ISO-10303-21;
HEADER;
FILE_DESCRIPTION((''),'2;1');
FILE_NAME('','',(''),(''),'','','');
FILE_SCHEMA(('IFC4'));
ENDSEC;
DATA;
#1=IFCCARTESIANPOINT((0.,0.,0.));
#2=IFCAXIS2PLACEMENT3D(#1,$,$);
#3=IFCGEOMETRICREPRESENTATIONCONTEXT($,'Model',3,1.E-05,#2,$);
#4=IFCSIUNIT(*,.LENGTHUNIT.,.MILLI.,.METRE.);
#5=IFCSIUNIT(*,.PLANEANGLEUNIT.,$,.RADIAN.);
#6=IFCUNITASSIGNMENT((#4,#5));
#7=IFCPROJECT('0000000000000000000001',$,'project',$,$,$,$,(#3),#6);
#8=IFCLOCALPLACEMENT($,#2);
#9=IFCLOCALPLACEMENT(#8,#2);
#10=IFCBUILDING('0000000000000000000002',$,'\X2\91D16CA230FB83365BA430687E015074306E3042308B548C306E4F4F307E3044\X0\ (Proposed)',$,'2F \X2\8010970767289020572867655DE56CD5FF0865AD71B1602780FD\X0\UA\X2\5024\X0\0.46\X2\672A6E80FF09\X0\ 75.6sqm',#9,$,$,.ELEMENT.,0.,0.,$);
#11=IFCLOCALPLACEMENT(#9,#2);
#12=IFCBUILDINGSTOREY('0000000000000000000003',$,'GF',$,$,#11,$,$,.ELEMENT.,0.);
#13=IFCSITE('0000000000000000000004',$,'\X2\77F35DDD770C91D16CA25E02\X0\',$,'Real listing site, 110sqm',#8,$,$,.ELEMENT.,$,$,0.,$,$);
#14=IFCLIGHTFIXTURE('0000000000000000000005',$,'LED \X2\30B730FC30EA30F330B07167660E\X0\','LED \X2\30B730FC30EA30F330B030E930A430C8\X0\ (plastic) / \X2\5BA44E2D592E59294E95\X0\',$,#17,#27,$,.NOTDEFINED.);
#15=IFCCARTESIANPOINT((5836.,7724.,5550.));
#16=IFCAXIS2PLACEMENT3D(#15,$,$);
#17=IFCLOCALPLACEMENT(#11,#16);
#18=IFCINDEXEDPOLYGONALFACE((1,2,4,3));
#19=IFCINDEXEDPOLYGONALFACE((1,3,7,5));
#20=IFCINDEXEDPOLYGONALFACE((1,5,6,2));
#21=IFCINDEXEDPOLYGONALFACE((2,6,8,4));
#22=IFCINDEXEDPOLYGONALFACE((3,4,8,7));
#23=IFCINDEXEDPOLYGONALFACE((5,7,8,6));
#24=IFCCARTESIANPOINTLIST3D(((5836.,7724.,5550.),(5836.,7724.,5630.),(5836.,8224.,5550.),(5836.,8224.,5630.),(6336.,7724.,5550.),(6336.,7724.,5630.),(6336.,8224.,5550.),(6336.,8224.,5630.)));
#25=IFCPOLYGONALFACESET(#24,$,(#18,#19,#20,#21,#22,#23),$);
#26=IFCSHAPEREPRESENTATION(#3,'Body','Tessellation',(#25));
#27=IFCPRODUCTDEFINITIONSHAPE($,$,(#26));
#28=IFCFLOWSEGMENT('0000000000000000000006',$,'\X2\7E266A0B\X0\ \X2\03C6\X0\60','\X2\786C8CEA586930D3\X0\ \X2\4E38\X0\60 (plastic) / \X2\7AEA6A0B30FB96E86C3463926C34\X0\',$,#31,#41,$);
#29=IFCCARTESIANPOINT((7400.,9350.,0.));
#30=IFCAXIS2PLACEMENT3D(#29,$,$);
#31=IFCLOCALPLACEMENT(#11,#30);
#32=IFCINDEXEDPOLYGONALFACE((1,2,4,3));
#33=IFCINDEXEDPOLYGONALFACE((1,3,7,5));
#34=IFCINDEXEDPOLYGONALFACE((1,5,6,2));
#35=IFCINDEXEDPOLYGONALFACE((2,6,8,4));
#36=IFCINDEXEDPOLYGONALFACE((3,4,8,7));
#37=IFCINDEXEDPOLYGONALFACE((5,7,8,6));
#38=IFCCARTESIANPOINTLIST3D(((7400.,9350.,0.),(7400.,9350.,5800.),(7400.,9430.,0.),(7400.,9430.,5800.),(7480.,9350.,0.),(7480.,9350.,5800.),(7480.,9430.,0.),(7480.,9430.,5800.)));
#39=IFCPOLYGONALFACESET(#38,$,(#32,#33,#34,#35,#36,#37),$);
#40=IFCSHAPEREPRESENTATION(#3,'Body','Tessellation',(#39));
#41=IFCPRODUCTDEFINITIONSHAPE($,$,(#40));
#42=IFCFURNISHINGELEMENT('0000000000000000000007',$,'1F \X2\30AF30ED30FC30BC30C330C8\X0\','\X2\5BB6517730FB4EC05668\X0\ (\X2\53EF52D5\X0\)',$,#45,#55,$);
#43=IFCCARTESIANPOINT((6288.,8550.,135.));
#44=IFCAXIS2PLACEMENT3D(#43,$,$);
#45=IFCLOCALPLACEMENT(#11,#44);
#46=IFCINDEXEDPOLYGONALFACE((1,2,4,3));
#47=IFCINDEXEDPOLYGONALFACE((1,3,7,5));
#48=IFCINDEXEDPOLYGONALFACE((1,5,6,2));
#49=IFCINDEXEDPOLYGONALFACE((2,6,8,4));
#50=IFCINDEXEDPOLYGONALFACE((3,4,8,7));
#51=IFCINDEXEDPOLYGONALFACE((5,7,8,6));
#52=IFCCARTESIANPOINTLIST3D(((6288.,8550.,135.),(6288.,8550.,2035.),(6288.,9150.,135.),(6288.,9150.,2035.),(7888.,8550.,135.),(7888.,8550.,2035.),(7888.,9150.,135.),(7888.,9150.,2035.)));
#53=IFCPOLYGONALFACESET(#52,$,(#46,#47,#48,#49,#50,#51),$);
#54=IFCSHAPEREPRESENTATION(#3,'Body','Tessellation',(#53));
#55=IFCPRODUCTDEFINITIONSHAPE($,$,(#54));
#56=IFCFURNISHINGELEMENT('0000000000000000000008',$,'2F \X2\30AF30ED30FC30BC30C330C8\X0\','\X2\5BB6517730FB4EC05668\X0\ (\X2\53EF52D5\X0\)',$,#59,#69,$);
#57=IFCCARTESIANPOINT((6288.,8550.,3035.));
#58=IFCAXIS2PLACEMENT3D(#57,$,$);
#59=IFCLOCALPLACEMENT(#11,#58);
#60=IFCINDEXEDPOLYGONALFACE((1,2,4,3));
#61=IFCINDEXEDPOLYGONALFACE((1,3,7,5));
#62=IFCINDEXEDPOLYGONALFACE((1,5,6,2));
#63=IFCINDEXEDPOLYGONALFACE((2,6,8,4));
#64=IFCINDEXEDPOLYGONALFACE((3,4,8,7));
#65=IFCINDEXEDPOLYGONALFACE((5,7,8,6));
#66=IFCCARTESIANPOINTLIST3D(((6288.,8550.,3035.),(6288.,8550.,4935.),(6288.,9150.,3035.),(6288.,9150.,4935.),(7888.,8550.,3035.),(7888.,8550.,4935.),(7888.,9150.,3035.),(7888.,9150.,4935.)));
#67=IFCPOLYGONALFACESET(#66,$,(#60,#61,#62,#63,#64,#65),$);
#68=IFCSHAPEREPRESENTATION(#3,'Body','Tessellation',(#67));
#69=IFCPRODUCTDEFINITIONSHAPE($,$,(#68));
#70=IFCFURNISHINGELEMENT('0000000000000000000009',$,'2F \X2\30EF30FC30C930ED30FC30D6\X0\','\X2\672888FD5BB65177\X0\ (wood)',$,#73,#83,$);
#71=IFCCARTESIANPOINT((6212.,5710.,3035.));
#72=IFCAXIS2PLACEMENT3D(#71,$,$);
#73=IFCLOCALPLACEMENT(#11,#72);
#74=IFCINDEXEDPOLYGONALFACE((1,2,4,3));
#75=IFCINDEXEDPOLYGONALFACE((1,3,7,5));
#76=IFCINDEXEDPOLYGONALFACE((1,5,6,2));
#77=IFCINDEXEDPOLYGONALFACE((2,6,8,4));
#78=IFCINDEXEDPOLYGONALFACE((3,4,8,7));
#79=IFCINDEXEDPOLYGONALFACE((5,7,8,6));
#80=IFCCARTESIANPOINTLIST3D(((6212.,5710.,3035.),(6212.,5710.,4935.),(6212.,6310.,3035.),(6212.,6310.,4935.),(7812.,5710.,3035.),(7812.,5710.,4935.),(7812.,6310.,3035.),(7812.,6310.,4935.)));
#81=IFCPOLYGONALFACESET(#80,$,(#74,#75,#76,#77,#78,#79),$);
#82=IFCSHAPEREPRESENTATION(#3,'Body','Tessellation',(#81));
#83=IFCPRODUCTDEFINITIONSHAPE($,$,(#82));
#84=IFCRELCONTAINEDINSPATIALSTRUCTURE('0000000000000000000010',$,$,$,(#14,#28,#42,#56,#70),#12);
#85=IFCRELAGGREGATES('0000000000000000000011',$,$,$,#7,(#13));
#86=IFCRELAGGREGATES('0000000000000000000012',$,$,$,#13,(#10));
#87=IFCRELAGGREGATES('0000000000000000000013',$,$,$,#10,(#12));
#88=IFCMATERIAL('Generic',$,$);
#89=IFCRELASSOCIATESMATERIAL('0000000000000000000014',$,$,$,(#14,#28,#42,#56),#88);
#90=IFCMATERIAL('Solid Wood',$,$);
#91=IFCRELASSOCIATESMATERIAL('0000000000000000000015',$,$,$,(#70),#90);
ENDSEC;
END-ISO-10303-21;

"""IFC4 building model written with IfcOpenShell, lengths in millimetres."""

from ifc_helpers import new_model, si_unit, frame, frame_2d, origin, place, context, project, spatial, rectangle, extrude, material, element, save


model = new_model("IFC4")

# Units and contexts
model_context = context("Model", 3, precision=1e-05, world=origin())
ifc_project = project(units=[si_unit("LENGTHUNIT", "METRE", prefix="MILLI"), si_unit("PLANEANGLEUNIT", "RADIAN")], contexts=[model_context])

# Site, building, storey
site_placement = place(None, origin())
site = spatial("IfcSite", under=ifc_project, at=site_placement, Name="石川県金沢市", ObjectType="Real listing site, 110sqm", CompositionType="ELEMENT", RefElevation=0.0)
building_placement = place(site_placement, origin())
building = spatial("IfcBuilding", under=site, at=building_placement, Name="金沢・茶室と縁側のある和の住まい (Proposed)", ObjectType="2F 耐震木造在来工法（断熱性能UA値0.46未満） 75.6sqm", CompositionType="ELEMENT", ElevationOfRefHeight=0.0, ElevationOfTerrain=0.0)
storey_placement = place(building_placement, origin())
storey = spatial("IfcBuildingStorey", under=building, at=storey_placement, Name="GF", CompositionType="ELEMENT", Elevation=0.0)

# Shared definitions
ifc_material_1 = material(Name="Solid Wood")

# Shared definitions
ifc_material_2 = material(Name="Generic")

# Light fixture
light_fixture_1_placement = place(storey_placement, frame((5836.0, 7724.0, 5550.0)))
element("IfcLightFixture", 1, at=light_fixture_1_placement, inside=storey, material=ifc_material_2, Name="LED シーリング照明", Description="LED シーリングライト (plastic) / 室中央天井", PredefinedType="NOTDEFINED", context=model_context, shape_type="SweptSolid", body=[
    extrude(rectangle(XDim=500.0, YDim=500.0, at=frame_2d((250.0, 250.0))), frame((5836.0, 7724.0, 5550.0)), (0.0, 0.0, 1.0), 80.0),
])

# Flow segment
flow_segment_placement = place(storey_placement, frame((7400.0, 9350.0, 0.0)))
element("IfcFlowSegment", 2, at=flow_segment_placement, inside=storey, material=ifc_material_2, Name="縦樋 φ60", Description="硬質塩ビ 丸60 (plastic) / 竪樋・雨水排水", context=model_context, shape_type="SweptSolid", body=[
    extrude(rectangle(XDim=80.0, YDim=80.0, at=frame_2d((40.0, 40.0))), frame((7400.0, 9350.0, 0.0)), (0.0, 0.0, 1.0), 5800.0),
])

# Furnishing elements
furnishing_1_placement = place(storey_placement, frame((6288.0, 8550.0, 135.0)))
element("IfcFurnishingElement", 3, at=furnishing_1_placement, inside=storey, material=ifc_material_2, Name="1F クローゼット", Description="家具・什器 (可動)", context=model_context, shape_type="SweptSolid", body=[
    extrude(rectangle(XDim=1600.0, YDim=600.0, at=frame_2d((800.0, 300.0))), frame((6288.0, 8550.0, 135.0)), (0.0, 0.0, 1.0), 1900.0),
])
furnishing_2_placement = place(storey_placement, frame((6288.0, 8550.0, 3035.0)))
element("IfcFurnishingElement", 4, at=furnishing_2_placement, inside=storey, material=ifc_material_2, Name="2F クローゼット", Description="家具・什器 (可動)", context=model_context, shape_type="SweptSolid", body=[
    extrude(rectangle(XDim=1600.0, YDim=600.0, at=frame_2d((800.0, 300.0))), frame((6288.0, 8550.0, 3035.0)), (0.0, 0.0, 1.0), 1900.0),
])
furnishing_3_placement = place(storey_placement, frame((6212.0, 5710.0, 3035.0)))
element("IfcFurnishingElement", 5, at=furnishing_3_placement, inside=storey, material=ifc_material_1, Name="2F ワードローブ", Description="木製家具 (wood)", context=model_context, shape_type="SweptSolid", body=[
    extrude(rectangle(XDim=1600.0, YDim=600.0, at=frame_2d((800.0, 300.0))), frame((6212.0, 5710.0, 3035.0)), (0.0, 0.0, 1.0), 1900.0),
])

save(model, "model.ifc")
